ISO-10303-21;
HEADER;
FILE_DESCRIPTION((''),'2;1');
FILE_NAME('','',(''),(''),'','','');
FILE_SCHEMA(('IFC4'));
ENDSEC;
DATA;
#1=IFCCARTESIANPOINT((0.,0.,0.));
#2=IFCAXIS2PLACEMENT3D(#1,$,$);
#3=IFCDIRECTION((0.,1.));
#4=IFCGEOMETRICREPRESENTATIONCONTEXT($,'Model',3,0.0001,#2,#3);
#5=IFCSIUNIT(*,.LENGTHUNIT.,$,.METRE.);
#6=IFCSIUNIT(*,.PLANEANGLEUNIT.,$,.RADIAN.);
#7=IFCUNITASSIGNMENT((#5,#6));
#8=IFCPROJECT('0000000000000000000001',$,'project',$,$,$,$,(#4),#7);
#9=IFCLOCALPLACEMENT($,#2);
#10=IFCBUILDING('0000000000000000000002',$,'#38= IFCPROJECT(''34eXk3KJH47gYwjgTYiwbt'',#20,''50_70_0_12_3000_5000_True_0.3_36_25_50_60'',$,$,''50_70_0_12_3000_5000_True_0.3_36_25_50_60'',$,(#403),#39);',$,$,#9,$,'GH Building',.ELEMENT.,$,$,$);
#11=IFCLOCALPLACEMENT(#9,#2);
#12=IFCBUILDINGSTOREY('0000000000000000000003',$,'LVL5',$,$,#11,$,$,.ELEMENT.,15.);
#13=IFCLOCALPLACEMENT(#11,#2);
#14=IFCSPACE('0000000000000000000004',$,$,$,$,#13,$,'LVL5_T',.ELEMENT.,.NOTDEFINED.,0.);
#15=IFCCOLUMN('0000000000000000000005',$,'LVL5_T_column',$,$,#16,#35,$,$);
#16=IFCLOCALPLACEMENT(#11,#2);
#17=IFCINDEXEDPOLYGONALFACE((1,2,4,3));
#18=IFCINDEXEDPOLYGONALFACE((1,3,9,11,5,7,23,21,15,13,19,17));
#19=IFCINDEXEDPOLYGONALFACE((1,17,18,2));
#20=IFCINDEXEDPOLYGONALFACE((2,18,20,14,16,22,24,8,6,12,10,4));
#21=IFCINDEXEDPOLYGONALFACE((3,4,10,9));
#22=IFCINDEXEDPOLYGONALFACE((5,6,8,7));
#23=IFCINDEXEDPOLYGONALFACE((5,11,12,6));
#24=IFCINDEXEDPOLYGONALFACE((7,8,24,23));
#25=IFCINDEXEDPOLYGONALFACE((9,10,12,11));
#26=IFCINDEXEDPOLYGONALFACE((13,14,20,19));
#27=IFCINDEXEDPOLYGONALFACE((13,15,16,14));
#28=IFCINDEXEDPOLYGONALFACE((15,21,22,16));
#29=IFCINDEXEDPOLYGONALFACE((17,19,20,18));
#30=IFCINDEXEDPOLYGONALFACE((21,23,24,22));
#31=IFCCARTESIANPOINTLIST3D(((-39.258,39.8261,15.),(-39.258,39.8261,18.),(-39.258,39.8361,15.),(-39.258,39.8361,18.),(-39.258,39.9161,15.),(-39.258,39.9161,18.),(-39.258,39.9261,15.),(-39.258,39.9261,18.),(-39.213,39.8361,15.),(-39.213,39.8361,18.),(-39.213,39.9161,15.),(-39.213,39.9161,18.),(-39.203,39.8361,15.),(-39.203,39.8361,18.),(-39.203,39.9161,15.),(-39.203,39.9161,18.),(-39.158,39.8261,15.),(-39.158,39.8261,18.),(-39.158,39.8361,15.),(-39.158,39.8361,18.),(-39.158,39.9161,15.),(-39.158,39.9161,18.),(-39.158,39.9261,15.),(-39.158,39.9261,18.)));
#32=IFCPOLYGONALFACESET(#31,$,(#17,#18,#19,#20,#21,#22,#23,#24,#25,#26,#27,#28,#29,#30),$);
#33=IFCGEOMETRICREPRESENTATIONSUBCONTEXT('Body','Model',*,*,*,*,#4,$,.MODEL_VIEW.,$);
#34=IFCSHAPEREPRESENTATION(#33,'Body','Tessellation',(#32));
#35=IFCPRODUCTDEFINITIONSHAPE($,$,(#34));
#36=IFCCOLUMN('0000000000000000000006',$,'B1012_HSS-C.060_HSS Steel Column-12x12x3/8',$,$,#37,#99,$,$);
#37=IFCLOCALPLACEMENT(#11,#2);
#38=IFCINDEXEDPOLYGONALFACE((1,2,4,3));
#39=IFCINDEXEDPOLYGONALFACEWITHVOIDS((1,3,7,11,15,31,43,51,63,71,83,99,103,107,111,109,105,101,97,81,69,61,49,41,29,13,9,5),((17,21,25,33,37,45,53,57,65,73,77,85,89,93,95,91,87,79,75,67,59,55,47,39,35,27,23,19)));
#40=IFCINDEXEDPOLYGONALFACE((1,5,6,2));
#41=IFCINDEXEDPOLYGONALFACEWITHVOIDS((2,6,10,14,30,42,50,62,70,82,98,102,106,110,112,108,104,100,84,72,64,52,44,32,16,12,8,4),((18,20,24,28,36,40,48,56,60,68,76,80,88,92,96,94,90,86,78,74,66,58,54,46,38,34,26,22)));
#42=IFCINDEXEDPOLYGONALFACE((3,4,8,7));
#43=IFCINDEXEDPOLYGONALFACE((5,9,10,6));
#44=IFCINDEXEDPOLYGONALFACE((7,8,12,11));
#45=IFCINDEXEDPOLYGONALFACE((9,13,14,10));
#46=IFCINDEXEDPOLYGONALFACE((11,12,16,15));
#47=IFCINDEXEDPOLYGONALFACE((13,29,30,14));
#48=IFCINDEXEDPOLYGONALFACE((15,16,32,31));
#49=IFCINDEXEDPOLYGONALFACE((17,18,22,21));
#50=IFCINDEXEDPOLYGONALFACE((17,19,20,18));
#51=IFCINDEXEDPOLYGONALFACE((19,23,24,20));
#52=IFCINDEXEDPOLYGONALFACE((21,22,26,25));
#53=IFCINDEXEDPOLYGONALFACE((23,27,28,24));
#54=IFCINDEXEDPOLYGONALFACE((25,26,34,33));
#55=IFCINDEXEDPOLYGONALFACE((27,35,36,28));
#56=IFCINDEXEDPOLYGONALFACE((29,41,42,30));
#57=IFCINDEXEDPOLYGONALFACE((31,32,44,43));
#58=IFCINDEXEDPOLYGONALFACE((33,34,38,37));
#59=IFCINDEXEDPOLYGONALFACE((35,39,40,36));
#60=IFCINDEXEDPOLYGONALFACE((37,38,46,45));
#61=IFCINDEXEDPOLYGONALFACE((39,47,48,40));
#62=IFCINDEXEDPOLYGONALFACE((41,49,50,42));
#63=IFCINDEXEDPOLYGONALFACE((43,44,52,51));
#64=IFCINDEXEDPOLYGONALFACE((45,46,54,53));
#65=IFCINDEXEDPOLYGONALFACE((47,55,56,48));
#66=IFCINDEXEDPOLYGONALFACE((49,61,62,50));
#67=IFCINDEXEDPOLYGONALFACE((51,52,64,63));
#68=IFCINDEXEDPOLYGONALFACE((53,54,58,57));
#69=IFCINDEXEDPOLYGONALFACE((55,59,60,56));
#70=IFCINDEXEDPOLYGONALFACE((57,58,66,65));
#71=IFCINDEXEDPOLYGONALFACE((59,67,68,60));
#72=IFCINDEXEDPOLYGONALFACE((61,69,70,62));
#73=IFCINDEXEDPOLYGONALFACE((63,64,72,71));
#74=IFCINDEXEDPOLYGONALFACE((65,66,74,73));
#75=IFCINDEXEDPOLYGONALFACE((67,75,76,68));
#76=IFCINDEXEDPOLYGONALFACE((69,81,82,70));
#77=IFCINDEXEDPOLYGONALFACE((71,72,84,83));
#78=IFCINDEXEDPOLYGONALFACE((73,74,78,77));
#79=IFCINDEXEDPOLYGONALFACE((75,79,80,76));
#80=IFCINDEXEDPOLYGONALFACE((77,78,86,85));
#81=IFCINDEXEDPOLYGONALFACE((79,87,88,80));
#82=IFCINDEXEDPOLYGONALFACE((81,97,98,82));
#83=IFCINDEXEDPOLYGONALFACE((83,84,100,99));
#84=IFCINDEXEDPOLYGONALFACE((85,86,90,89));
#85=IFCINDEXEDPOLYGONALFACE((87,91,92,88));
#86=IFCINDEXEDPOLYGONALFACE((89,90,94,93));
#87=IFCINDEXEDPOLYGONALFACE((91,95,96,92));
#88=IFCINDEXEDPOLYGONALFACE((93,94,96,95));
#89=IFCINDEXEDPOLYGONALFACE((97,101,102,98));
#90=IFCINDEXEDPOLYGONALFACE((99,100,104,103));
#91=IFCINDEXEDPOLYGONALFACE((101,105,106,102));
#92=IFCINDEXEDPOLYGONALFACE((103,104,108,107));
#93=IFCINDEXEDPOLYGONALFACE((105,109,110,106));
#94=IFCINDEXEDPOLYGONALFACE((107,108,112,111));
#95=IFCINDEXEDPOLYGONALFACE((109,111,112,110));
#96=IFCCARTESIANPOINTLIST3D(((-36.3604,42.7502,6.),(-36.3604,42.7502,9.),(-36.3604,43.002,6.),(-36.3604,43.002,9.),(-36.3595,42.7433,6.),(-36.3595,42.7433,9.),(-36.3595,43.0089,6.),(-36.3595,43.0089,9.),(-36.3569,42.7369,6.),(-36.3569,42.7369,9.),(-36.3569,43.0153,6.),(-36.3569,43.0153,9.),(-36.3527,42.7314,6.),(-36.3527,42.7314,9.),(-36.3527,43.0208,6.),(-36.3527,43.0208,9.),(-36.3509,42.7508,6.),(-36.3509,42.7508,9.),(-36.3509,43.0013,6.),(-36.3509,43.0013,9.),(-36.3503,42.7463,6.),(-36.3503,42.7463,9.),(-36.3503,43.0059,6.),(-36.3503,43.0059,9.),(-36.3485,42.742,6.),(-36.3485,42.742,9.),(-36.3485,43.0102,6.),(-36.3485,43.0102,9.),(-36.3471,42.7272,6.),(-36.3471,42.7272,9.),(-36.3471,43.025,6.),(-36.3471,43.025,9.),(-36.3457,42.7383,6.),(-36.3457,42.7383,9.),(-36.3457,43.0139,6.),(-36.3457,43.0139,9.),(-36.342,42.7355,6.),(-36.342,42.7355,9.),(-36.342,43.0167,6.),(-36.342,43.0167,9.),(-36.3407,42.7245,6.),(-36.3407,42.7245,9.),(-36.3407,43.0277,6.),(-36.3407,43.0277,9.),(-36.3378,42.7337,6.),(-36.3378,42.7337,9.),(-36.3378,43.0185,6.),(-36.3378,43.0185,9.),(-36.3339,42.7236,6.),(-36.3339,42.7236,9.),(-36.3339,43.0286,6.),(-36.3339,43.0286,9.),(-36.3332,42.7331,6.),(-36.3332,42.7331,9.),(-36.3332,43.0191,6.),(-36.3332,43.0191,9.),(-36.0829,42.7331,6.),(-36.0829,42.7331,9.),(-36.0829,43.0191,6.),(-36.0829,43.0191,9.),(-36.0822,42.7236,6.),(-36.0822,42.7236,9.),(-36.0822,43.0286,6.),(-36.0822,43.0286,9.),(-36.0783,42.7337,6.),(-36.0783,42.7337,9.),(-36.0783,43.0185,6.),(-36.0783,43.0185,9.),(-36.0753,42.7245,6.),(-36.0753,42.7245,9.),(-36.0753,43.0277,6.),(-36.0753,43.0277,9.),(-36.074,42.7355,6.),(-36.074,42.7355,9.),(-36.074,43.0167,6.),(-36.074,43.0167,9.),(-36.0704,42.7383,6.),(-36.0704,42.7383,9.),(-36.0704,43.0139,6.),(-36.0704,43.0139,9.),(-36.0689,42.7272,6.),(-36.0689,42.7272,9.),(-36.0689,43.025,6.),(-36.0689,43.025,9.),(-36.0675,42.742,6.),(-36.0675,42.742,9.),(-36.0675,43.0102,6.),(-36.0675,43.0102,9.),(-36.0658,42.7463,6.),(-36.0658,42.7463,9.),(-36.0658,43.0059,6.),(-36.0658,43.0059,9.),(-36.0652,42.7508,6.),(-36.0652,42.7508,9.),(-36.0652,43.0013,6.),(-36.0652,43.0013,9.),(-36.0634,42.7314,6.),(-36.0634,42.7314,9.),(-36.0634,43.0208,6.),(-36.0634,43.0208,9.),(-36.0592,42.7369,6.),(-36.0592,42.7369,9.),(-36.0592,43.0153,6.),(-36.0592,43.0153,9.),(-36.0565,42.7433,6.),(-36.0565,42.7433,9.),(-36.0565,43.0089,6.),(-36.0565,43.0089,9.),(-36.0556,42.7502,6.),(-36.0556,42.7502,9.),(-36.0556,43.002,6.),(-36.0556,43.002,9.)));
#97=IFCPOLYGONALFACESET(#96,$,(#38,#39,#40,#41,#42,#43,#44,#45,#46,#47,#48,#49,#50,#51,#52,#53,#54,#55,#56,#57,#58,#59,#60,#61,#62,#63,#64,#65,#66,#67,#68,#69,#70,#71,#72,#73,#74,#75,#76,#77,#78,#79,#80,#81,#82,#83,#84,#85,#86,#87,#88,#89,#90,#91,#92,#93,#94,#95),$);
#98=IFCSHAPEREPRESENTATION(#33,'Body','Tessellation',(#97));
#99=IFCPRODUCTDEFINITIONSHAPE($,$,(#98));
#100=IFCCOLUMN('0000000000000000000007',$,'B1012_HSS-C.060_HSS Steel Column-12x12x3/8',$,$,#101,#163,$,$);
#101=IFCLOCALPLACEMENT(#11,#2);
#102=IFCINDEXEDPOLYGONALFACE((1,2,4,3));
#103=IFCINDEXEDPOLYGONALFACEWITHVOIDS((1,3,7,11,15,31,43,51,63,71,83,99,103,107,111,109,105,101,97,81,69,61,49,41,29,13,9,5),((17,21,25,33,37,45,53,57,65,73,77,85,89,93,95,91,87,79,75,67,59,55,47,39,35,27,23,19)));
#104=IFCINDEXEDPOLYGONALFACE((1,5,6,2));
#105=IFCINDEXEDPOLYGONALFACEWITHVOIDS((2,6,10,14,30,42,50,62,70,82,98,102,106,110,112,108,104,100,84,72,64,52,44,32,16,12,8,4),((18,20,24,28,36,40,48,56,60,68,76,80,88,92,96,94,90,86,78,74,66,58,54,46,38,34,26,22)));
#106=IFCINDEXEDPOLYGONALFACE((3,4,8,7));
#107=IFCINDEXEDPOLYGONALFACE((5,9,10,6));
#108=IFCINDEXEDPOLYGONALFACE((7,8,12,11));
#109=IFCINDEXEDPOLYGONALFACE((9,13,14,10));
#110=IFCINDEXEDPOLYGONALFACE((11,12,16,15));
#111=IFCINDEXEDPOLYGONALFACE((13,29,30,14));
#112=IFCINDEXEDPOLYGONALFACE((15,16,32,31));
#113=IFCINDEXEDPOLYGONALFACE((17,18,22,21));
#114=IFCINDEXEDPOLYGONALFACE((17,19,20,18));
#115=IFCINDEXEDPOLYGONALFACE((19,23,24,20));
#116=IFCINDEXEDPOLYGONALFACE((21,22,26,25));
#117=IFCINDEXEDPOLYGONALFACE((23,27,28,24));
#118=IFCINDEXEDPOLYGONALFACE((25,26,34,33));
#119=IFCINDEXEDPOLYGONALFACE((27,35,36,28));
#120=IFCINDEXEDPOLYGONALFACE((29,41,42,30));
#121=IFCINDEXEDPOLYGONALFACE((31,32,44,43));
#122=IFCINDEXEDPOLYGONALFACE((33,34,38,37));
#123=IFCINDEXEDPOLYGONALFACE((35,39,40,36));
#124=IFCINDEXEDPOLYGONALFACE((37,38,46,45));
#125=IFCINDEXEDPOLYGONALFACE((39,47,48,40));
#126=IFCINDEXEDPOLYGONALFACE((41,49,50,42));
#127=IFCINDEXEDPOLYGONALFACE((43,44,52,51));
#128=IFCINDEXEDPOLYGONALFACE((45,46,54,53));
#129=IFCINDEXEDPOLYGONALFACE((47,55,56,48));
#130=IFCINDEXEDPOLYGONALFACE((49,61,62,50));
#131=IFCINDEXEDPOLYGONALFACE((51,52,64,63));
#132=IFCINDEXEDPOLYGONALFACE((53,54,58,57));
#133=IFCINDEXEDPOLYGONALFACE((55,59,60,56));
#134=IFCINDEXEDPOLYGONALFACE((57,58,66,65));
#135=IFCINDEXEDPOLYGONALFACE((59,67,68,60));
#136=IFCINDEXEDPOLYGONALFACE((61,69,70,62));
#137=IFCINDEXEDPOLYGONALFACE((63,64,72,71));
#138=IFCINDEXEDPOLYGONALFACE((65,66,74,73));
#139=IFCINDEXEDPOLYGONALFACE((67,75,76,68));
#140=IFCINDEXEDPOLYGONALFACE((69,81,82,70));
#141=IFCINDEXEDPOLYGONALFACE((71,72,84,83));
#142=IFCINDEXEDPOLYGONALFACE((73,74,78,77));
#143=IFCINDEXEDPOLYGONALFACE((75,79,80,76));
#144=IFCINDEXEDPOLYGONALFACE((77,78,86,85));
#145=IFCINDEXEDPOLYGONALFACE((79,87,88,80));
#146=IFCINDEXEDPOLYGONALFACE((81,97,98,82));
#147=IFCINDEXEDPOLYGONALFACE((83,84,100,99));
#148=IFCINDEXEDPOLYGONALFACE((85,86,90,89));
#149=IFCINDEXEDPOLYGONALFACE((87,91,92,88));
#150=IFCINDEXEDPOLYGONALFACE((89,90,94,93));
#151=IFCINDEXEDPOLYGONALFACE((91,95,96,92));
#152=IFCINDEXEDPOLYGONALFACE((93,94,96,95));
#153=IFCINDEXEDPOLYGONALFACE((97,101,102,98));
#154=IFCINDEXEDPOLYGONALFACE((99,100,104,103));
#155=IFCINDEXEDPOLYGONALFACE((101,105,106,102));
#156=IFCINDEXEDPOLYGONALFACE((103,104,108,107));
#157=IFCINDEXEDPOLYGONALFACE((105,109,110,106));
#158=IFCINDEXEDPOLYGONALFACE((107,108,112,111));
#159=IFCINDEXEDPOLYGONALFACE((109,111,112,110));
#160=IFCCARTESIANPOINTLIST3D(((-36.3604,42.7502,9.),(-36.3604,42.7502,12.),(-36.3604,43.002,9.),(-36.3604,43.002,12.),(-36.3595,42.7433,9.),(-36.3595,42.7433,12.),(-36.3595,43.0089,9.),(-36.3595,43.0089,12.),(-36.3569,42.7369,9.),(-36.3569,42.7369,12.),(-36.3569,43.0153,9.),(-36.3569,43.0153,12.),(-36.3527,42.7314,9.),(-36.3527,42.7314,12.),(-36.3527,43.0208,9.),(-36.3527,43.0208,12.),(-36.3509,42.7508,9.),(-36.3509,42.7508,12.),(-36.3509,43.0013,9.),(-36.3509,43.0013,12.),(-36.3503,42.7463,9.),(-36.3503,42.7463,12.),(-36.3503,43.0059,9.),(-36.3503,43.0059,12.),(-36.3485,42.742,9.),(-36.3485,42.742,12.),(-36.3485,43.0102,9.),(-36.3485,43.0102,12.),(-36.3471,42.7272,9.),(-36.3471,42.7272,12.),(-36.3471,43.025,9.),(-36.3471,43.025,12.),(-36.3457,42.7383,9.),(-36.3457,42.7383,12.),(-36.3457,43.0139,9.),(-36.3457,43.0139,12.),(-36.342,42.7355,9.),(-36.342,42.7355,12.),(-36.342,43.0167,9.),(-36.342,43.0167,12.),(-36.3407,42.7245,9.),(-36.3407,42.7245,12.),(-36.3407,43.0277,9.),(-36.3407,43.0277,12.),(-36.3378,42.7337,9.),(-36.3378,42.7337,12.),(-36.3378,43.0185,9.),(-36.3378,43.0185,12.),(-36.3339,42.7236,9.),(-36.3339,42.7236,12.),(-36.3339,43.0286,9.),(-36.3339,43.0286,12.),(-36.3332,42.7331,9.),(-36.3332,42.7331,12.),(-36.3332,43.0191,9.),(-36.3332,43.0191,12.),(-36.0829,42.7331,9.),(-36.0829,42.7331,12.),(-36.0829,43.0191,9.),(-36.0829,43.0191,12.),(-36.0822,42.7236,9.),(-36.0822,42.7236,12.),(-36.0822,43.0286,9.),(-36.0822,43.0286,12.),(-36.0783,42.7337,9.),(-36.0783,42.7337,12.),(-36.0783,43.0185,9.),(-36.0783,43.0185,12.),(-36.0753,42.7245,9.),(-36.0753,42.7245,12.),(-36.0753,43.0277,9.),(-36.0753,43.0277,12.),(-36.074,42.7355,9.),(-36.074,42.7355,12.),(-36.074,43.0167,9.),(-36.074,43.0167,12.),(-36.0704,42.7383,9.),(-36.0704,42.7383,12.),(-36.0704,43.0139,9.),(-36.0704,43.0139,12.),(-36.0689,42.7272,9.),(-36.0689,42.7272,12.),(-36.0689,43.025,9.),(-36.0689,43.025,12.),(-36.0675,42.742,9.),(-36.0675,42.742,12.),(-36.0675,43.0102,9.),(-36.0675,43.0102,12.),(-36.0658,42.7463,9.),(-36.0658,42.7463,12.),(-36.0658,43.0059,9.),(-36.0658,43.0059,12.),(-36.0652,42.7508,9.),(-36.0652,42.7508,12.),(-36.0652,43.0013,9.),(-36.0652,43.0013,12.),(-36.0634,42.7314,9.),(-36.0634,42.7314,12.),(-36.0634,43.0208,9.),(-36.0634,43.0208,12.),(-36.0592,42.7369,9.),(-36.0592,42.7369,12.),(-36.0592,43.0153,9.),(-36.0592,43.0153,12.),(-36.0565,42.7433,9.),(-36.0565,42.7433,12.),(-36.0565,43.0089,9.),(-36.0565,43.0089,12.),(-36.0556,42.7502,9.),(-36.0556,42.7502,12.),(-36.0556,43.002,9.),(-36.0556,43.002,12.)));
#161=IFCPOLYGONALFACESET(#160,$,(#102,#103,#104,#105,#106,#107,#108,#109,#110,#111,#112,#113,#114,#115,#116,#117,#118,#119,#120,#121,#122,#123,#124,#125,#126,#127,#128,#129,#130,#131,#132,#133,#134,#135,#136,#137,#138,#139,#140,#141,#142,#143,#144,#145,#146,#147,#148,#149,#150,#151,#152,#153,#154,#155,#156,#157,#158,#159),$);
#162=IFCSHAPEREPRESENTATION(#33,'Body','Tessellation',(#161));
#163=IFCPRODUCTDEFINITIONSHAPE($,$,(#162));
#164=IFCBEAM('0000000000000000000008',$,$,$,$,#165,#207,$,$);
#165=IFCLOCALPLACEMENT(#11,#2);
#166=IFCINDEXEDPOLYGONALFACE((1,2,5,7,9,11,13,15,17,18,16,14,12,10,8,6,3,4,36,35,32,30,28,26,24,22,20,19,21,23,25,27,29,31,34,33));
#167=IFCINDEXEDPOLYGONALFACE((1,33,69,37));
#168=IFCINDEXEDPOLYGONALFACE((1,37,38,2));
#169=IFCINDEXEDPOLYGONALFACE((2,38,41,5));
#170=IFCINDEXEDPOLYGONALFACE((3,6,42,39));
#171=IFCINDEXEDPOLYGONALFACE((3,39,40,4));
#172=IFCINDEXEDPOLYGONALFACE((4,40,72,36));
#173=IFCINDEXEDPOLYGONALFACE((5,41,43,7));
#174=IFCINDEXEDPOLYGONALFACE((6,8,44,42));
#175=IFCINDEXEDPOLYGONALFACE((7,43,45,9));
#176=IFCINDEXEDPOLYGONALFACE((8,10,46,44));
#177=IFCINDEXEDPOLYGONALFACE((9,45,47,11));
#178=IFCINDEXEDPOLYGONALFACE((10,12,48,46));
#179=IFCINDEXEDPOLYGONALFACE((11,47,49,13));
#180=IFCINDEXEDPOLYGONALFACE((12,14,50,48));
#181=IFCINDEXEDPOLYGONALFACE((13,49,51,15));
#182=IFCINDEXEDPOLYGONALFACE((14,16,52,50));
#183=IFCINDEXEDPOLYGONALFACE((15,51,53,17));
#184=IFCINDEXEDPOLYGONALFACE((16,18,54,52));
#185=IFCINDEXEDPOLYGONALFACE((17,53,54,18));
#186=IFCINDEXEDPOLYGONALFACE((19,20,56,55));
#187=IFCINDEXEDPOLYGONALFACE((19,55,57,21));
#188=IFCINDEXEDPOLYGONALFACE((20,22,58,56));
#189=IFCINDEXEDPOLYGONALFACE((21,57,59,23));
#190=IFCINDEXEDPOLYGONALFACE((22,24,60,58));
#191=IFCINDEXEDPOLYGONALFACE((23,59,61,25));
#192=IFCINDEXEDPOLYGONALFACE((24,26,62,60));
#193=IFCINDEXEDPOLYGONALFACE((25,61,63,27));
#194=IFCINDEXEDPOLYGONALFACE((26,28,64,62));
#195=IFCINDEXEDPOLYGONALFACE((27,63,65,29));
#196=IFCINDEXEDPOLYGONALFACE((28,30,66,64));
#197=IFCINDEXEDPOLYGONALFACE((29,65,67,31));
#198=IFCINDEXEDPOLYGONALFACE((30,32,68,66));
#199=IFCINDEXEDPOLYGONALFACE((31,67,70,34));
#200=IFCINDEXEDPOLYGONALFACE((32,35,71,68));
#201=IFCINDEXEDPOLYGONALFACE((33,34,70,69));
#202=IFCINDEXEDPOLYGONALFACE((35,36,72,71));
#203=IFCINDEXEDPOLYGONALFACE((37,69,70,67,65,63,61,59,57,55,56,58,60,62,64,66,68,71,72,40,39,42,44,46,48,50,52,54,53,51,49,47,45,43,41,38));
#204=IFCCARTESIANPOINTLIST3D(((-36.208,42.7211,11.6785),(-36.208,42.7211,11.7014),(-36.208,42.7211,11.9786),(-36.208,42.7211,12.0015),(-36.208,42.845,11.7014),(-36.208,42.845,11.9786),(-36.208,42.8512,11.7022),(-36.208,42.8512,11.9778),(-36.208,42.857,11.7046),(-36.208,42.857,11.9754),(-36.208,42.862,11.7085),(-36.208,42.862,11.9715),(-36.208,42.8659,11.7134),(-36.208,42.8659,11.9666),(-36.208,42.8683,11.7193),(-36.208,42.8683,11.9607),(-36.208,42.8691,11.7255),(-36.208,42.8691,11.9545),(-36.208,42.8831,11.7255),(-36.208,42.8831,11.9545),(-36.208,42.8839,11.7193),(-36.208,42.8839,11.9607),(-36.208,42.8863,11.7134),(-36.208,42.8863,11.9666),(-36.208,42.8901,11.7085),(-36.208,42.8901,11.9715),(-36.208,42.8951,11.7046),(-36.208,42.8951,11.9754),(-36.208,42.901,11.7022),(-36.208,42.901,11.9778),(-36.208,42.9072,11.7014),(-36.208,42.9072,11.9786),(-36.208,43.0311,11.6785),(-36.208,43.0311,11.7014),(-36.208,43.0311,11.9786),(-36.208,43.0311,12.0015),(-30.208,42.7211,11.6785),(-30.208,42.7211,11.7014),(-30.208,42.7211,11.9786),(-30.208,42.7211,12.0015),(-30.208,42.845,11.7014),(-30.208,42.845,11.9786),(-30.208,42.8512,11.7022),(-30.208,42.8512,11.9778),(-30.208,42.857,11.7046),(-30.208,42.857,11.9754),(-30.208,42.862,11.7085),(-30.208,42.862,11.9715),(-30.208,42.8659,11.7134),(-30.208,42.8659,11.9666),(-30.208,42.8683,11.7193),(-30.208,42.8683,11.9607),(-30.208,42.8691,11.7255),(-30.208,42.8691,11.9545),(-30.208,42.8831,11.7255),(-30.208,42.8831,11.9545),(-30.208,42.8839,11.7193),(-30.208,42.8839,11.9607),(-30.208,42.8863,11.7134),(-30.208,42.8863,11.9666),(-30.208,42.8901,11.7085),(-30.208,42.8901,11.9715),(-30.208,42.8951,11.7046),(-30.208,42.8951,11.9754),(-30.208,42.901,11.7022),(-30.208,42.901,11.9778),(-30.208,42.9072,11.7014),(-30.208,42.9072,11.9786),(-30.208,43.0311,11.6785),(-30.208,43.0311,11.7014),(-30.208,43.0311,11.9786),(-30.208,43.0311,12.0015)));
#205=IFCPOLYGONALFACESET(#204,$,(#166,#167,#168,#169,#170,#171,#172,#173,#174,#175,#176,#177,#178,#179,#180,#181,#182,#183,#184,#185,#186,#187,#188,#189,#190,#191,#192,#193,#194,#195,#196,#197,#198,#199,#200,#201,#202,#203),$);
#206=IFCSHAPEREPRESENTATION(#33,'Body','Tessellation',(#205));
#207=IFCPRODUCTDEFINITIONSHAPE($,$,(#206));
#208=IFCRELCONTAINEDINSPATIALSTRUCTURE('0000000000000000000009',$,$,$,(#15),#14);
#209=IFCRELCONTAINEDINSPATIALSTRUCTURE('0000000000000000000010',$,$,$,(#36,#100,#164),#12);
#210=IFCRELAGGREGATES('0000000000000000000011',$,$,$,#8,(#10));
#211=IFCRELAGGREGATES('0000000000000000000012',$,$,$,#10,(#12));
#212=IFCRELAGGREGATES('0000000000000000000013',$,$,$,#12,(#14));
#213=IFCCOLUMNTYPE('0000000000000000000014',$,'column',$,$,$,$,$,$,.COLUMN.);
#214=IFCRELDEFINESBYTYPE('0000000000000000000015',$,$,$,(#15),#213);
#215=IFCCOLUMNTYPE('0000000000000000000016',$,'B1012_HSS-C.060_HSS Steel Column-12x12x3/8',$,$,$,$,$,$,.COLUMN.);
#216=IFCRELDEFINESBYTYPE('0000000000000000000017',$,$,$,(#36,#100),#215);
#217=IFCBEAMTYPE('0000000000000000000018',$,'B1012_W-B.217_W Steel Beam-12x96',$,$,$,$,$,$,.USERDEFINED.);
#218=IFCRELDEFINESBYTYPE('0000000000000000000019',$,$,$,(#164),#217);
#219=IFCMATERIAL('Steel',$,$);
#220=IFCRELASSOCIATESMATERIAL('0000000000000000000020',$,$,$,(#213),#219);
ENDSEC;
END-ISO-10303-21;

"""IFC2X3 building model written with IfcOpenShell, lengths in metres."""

from ifc_helpers import new_model, si_unit, direction, frame, origin, origin_2d, place, context, subcontext, project, spatial, hollow_rectangle, i_section, extrude, material, type_object, element, save


model = new_model("IFC2X3")

# Units and contexts
model_context = context("Model", 3, precision=0.0001, world=origin(), true_north=direction((0.0, 1.0)))
body_context = subcontext(model_context, "Body", "Model", "MODEL_VIEW")
ifc_project = project(units=[si_unit("LENGTHUNIT", "METRE"), si_unit("PLANEANGLEUNIT", "RADIAN")], contexts=[model_context])

# Building, storey, space
building_placement = place(None, origin())
building = spatial("IfcBuilding", under=ifc_project, at=building_placement, Name="#38= IFCPROJECT('34eXk3KJH47gYwjgTYiwbt',#20,'50_70_0_12_3000_5000_True_0.3_36_25_50_60',$,$,'50_70_0_12_3000_5000_True_0.3_36_25_50_60',$,(#403),#39);", LongName="GH Building", CompositionType="ELEMENT")
storey_placement = place(building_placement, origin())
storey = spatial("IfcBuildingStorey", under=building, at=storey_placement, Name="LVL5", CompositionType="ELEMENT", Elevation=15.0)
space_1_placement = place(storey_placement, origin())
space_1 = spatial("IfcSpace", under=storey, at=space_1_placement, LongName="LVL5_T", CompositionType="ELEMENT", InteriorOrExteriorSpace="NOTDEFINED", ElevationWithFlooring=0.0)

# Column
ifc_material_1 = material(Name="Steel")
column_type_1 = type_object("IfcColumnType", Name="column", PredefinedType="COLUMN", material=ifc_material_1)
for number, where, name in (
    (1, (-39.208, 39.8761, 15.0), "LVL5_T_column"),
):
    element("IfcColumn", number, at=place(space_1_placement, frame(where)), inside=space_1, type_object=column_type_1, Name=name, context=body_context, shape_type="SweptSolid", body=[
        extrude(i_section(OverallWidth=0.1, OverallDepth=0.1, WebThickness=0.01, FlangeThickness=0.01, at=origin_2d()), origin(), (0.0, 0.0, 1.0), 3.0),
    ])

# Columns
column_type_2 = type_object("IfcColumnType", Name="B1012_HSS-C.060_HSS Steel Column-12x12x3/8", PredefinedType="COLUMN")
for number, where, z_axis, x_axis, name in (
    (2, (-36.208, 42.8761, 9.0), (0.0, 0.0, -1.0), (-1.0, 0.0, 0.0), "B1012_HSS-C.060_HSS Steel Column-12x12x3/8"),
    (3, (-36.208, 42.8761, 12.0), (0.0, 0.0, -1.0), (-1.0, 0.0, 0.0), "B1012_HSS-C.060_HSS Steel Column-12x12x3/8"),
):
    element("IfcColumn", number, at=place(storey_placement, frame(where, z_axis=z_axis, x_axis=x_axis)), inside=storey, type_object=column_type_2, Name=name, context=body_context, shape_type="SweptSolid", body=[
        extrude(hollow_rectangle(XDim=0.3048, YDim=0.305, WallThickness=0.0095, InnerFilletRadius=0.0177, OuterFilletRadius=0.0266, at=origin_2d()), origin(), (0.0, 0.0, 1.0), 3.0),
    ])

# Beam
beam_type = type_object("IfcBeamType", Name="B1012_W-B.217_W Steel Beam-12x96", PredefinedType="USERDEFINED")
for number, where, z_axis, x_axis in (
    (4, (-36.208, 42.8761, 11.84), (1.0, 0.0, 0.0), (0.0, 1.0, 0.0)),
):
    element("IfcBeam", number, at=place(storey_placement, frame(where, z_axis=z_axis, x_axis=x_axis)), inside=storey, type_object=beam_type, context=body_context, shape_type="SweptSolid", body=[
        extrude(i_section(OverallWidth=0.31, OverallDepth=0.323, WebThickness=0.014, FlangeThickness=0.0229, FilletRadius=0.0241, at=origin_2d()), origin(), (0.0, 0.0, 1.0), 6.0),
    ])

save(model, "model.ifc")
